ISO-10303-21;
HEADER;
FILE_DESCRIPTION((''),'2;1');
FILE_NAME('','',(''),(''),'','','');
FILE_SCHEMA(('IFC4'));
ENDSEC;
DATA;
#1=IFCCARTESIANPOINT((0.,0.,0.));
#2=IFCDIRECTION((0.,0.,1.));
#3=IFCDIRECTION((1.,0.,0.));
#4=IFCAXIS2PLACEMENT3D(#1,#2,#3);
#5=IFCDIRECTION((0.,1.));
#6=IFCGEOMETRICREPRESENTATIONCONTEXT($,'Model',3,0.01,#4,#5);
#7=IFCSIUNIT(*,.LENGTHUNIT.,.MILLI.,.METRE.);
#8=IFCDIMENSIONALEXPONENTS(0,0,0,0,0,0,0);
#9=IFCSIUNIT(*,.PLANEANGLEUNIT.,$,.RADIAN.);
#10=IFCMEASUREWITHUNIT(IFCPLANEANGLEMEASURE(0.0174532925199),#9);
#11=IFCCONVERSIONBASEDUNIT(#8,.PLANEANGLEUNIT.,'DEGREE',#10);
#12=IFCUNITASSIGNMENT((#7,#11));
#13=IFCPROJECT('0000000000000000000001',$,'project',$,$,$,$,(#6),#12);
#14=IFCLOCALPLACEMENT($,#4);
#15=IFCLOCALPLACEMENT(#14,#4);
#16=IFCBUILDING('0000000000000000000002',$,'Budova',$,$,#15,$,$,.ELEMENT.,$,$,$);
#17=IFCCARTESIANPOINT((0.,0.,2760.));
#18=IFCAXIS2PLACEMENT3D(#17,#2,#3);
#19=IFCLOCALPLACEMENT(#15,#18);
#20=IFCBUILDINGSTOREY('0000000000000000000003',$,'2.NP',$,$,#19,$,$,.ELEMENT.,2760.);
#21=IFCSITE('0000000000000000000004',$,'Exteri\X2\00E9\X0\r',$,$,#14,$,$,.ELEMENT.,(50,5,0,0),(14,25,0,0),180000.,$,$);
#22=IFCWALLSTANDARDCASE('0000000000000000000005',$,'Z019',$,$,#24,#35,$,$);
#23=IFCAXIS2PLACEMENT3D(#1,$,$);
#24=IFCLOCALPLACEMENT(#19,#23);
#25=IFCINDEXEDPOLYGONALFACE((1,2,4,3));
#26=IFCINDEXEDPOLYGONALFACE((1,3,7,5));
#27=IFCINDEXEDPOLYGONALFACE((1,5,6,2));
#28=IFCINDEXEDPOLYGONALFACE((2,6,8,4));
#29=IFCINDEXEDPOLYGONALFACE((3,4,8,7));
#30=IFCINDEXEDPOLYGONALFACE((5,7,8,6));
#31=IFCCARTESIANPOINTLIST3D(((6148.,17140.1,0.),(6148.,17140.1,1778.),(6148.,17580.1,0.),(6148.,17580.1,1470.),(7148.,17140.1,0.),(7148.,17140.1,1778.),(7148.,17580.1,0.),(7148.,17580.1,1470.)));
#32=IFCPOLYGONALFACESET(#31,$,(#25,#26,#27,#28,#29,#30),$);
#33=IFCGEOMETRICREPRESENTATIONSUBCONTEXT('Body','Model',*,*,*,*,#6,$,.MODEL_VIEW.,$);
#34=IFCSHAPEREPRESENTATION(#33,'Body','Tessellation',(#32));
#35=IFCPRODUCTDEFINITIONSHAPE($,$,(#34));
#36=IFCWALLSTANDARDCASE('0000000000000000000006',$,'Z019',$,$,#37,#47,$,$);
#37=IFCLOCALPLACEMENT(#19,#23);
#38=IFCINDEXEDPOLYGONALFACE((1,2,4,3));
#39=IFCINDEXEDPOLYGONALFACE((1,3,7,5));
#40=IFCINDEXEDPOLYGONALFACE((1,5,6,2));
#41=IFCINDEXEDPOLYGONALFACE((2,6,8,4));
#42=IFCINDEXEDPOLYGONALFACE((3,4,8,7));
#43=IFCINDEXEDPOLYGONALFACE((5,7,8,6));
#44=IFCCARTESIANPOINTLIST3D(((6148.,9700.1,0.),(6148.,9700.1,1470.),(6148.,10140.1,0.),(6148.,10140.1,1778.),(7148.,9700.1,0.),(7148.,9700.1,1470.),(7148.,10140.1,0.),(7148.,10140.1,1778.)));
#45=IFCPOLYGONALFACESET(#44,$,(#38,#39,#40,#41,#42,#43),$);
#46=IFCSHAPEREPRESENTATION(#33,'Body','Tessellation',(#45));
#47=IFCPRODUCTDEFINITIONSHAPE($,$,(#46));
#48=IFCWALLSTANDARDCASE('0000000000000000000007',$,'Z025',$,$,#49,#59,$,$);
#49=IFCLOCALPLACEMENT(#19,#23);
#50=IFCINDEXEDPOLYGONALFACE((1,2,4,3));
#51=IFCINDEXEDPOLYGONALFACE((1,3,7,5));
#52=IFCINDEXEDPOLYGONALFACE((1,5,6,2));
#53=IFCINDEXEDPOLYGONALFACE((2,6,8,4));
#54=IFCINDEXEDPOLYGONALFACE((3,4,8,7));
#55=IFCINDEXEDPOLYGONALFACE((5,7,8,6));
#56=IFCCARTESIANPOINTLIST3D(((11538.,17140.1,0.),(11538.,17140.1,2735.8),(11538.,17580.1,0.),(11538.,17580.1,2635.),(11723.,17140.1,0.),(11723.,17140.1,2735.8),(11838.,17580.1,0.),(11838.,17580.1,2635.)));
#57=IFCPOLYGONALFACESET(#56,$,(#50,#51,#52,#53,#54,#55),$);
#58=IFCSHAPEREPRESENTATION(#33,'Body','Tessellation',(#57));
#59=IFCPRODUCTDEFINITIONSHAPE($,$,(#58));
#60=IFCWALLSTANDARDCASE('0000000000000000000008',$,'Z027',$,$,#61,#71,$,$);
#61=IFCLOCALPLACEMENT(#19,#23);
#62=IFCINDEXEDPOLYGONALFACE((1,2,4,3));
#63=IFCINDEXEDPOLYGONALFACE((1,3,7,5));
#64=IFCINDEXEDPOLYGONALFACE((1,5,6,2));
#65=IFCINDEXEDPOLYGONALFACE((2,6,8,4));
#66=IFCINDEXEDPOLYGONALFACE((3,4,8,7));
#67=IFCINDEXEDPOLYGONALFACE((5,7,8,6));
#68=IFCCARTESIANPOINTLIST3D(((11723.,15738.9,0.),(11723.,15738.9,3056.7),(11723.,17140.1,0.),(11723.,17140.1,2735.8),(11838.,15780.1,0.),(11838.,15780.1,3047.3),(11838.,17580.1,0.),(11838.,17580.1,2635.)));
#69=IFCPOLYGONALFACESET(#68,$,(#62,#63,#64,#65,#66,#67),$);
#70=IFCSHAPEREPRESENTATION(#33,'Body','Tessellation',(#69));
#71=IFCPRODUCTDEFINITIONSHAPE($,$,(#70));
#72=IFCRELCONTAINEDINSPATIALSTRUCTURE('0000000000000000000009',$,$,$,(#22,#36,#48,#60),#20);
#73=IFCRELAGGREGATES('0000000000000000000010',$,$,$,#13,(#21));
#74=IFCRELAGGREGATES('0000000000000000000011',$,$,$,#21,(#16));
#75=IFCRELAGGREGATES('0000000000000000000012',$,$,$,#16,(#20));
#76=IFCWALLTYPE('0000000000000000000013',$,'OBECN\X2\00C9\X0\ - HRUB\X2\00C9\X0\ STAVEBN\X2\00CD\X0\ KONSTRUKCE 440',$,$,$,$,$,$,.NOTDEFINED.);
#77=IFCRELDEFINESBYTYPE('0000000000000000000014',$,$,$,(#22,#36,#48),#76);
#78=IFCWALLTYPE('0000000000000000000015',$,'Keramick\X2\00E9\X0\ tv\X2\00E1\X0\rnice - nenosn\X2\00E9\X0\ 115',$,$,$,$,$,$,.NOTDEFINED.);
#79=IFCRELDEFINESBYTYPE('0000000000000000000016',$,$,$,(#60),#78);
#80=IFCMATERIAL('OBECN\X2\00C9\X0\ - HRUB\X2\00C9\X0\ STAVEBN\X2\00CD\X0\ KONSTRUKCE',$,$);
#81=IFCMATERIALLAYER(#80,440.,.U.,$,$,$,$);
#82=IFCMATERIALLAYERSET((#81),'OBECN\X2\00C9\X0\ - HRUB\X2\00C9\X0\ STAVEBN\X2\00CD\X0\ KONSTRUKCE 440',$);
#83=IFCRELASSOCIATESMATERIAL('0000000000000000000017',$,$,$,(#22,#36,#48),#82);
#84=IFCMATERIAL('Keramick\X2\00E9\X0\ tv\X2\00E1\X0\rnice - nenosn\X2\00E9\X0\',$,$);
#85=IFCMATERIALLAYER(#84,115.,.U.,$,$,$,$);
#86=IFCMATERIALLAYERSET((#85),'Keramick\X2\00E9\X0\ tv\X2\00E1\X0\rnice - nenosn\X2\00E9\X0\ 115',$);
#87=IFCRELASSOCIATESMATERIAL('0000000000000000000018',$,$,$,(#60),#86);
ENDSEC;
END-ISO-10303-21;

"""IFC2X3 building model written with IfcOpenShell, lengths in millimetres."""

from ifc_helpers import new_model, entity, si_unit, converted_unit, direction, frame, origin_with_axes, place, context, subcontext, project, spatial, polyline, outline, extrude, clip, halfspace, material, layer, layer_set, layer_usage, type_object, element, save


model = new_model("IFC2X3")

# Units and contexts
model_context = context("Model", 3, precision=0.01, world=origin_with_axes(), true_north=direction((0.0, 1.0)))
body_context = subcontext(model_context, "Body", "Model", "MODEL_VIEW")
ifc_project = project(units=[si_unit("LENGTHUNIT", "METRE", prefix="MILLI"), converted_unit("PLANEANGLEUNIT", "DEGREE", entity("IfcPlaneAngleMeasure", 0.0174532925199), si_unit("PLANEANGLEUNIT", "RADIAN"), dimensions=[0, 0, 0, 0, 0, 0, 0])], contexts=[model_context])

# Site, building, storey
site_placement = place(None, origin_with_axes())
site = spatial("IfcSite", under=ifc_project, at=site_placement, Name="Exteriér", CompositionType="ELEMENT", RefLatitude=(50, 5, 0, 0), RefLongitude=(14, 25, 0, 0), RefElevation=180000.0)
building_placement = place(site_placement, origin_with_axes())
building = spatial("IfcBuilding", under=site, at=building_placement, Name="Budova", CompositionType="ELEMENT")
storey_placement = place(building_placement, frame((0.0, 0.0, 2760.0), z_axis=(0.0, 0.0, 1.0), x_axis=(1.0, 0.0, 0.0)))
storey = spatial("IfcBuildingStorey", under=building, at=storey_placement, Name="2.NP", CompositionType="ELEMENT", Elevation=2760.0)

# Shared definitions
ifc_material_1 = material(Name="OBECNÉ - HRUBÉ STAVEBNÍ KONSTRUKCE")
ifc_layer_1 = layer(ifc_material_1, 440.0, ventilated="UNKNOWN")
ifc_layer_set_1 = layer_set([ifc_layer_1], Name="OBECNÉ - HRUBÉ STAVEBNÍ KONSTRUKCE 440")
wall_type_1 = type_object("IfcWallType", Name="OBECNÉ - HRUBÉ STAVEBNÍ KONSTRUKCE 440", PredefinedType="NOTDEFINED")

# Walls
ifc_layer_usage_1 = layer_usage(ifc_layer_set_1, "AXIS2", "POSITIVE", -440.0)
wall_1_placement = place(storey_placement, frame((6148.0, 17580.1, 0.0), z_axis=(0.0, 0.0, 1.0), x_axis=(1.0, 0.0, 0.0)))
element("IfcWallStandardCase", 1, at=wall_1_placement, inside=storey, type_object=wall_type_1, material=ifc_layer_usage_1, Name="Z019", context=body_context, shape_type="Clipping", body=[
    clip(extrude(outline(polyline([(0.0, -440.0), (1000.0, -440.0), (1000.0, 0.0), (0.0, 0.0), (0.0, -440.0)])), origin_with_axes(), (0.0, 0.0, 1.0), 2000.0), halfspace(frame((0.0, 690.7, 986.4), z_axis=(0.0, -0.573576, -0.819152), x_axis=(0.0, 0.819152, -0.573576)), True)),
])
ifc_layer_usage_2 = layer_usage(ifc_layer_set_1, "AXIS2", "NEGATIVE", 440.0)
wall_2_placement = place(storey_placement, frame((6148.0, 9700.1, 0.0), z_axis=(0.0, 0.0, 1.0), x_axis=(1.0, 0.0, 0.0)))
element("IfcWallStandardCase", 2, at=wall_2_placement, inside=storey, type_object=wall_type_1, material=ifc_layer_usage_2, Name="Z019", context=body_context, shape_type="Clipping", body=[
    clip(extrude(outline(polyline([(0.0, 0.0), (1000.0, 0.0), (1000.0, 440.0), (0.0, 440.0), (0.0, 0.0)])), origin_with_axes(), (0.0, 0.0, 1.0), 2000.0), halfspace(frame((0.0, -690.7, 986.4), z_axis=(0.0, 0.573576, -0.819152), x_axis=(0.0, 0.819152, 0.573576)), True)),
])
ifc_layer_usage_3 = layer_usage(ifc_layer_set_1, "AXIS2", "POSITIVE", -440.0)
wall_3_placement = place(storey_placement, frame((11538.0, 17580.1, 0.0), z_axis=(0.0, 0.0, 1.0), x_axis=(1.0, 0.0, 0.0)))
element("IfcWallStandardCase", 3, at=wall_3_placement, inside=storey, type_object=wall_type_1, material=ifc_layer_usage_3, Name="Z025", context=body_context, shape_type="Clipping", body=[
    clip(extrude(outline(polyline([(0.0, -440.0), (185.0, -440.0), (300.0, 0.0), (0.0, 0.0), (0.0, -440.0)])), origin_with_axes(), (0.0, 0.0, 1.0), 3000.0), halfspace(frame((0.0, 573.4, 2503.7), z_axis=(0.0, -0.22325, -0.974761), x_axis=(0.0, 0.974761, -0.22325)), True)),
])

# Shared definitions
ifc_material_2 = material(Name="Keramické tvárnice - nenosné")
ifc_layer_2 = layer(ifc_material_2, 115.0, ventilated="UNKNOWN")
ifc_layer_set_2 = layer_set([ifc_layer_2], Name="Keramické tvárnice - nenosné 115")
wall_type_2 = type_object("IfcWallType", Name="Keramické tvárnice - nenosné 115", PredefinedType="NOTDEFINED")

# Wall
ifc_layer_usage_4 = layer_usage(ifc_layer_set_2, "AXIS2", "POSITIVE", -115.0)
wall_4_placement = place(storey_placement, frame((11838.0, 17580.1, 0.0), z_axis=(0.0, 0.0, 1.0), x_axis=(0.0, -1.0, 0.0)))
element("IfcWallStandardCase", 4, at=wall_4_placement, inside=storey, type_object=wall_type_2, material=ifc_layer_usage_4, Name="Z027", context=body_context, shape_type="Clipping", body=[
    clip(extrude(outline(polyline([(440.0, -115.0), (1841.2, -115.0), (1800.0, 0.0), (0.0, 0.0), (440.0, -115.0)])), origin_with_axes(), (0.0, 0.0, 1.0), 5000.0), halfspace(frame((-573.4, 0.0, 2503.7), z_axis=(0.22325, 0.0, -0.974761), x_axis=(0.0, 1.0, 0.0)), True)),
])

save(model, "model.ifc")
